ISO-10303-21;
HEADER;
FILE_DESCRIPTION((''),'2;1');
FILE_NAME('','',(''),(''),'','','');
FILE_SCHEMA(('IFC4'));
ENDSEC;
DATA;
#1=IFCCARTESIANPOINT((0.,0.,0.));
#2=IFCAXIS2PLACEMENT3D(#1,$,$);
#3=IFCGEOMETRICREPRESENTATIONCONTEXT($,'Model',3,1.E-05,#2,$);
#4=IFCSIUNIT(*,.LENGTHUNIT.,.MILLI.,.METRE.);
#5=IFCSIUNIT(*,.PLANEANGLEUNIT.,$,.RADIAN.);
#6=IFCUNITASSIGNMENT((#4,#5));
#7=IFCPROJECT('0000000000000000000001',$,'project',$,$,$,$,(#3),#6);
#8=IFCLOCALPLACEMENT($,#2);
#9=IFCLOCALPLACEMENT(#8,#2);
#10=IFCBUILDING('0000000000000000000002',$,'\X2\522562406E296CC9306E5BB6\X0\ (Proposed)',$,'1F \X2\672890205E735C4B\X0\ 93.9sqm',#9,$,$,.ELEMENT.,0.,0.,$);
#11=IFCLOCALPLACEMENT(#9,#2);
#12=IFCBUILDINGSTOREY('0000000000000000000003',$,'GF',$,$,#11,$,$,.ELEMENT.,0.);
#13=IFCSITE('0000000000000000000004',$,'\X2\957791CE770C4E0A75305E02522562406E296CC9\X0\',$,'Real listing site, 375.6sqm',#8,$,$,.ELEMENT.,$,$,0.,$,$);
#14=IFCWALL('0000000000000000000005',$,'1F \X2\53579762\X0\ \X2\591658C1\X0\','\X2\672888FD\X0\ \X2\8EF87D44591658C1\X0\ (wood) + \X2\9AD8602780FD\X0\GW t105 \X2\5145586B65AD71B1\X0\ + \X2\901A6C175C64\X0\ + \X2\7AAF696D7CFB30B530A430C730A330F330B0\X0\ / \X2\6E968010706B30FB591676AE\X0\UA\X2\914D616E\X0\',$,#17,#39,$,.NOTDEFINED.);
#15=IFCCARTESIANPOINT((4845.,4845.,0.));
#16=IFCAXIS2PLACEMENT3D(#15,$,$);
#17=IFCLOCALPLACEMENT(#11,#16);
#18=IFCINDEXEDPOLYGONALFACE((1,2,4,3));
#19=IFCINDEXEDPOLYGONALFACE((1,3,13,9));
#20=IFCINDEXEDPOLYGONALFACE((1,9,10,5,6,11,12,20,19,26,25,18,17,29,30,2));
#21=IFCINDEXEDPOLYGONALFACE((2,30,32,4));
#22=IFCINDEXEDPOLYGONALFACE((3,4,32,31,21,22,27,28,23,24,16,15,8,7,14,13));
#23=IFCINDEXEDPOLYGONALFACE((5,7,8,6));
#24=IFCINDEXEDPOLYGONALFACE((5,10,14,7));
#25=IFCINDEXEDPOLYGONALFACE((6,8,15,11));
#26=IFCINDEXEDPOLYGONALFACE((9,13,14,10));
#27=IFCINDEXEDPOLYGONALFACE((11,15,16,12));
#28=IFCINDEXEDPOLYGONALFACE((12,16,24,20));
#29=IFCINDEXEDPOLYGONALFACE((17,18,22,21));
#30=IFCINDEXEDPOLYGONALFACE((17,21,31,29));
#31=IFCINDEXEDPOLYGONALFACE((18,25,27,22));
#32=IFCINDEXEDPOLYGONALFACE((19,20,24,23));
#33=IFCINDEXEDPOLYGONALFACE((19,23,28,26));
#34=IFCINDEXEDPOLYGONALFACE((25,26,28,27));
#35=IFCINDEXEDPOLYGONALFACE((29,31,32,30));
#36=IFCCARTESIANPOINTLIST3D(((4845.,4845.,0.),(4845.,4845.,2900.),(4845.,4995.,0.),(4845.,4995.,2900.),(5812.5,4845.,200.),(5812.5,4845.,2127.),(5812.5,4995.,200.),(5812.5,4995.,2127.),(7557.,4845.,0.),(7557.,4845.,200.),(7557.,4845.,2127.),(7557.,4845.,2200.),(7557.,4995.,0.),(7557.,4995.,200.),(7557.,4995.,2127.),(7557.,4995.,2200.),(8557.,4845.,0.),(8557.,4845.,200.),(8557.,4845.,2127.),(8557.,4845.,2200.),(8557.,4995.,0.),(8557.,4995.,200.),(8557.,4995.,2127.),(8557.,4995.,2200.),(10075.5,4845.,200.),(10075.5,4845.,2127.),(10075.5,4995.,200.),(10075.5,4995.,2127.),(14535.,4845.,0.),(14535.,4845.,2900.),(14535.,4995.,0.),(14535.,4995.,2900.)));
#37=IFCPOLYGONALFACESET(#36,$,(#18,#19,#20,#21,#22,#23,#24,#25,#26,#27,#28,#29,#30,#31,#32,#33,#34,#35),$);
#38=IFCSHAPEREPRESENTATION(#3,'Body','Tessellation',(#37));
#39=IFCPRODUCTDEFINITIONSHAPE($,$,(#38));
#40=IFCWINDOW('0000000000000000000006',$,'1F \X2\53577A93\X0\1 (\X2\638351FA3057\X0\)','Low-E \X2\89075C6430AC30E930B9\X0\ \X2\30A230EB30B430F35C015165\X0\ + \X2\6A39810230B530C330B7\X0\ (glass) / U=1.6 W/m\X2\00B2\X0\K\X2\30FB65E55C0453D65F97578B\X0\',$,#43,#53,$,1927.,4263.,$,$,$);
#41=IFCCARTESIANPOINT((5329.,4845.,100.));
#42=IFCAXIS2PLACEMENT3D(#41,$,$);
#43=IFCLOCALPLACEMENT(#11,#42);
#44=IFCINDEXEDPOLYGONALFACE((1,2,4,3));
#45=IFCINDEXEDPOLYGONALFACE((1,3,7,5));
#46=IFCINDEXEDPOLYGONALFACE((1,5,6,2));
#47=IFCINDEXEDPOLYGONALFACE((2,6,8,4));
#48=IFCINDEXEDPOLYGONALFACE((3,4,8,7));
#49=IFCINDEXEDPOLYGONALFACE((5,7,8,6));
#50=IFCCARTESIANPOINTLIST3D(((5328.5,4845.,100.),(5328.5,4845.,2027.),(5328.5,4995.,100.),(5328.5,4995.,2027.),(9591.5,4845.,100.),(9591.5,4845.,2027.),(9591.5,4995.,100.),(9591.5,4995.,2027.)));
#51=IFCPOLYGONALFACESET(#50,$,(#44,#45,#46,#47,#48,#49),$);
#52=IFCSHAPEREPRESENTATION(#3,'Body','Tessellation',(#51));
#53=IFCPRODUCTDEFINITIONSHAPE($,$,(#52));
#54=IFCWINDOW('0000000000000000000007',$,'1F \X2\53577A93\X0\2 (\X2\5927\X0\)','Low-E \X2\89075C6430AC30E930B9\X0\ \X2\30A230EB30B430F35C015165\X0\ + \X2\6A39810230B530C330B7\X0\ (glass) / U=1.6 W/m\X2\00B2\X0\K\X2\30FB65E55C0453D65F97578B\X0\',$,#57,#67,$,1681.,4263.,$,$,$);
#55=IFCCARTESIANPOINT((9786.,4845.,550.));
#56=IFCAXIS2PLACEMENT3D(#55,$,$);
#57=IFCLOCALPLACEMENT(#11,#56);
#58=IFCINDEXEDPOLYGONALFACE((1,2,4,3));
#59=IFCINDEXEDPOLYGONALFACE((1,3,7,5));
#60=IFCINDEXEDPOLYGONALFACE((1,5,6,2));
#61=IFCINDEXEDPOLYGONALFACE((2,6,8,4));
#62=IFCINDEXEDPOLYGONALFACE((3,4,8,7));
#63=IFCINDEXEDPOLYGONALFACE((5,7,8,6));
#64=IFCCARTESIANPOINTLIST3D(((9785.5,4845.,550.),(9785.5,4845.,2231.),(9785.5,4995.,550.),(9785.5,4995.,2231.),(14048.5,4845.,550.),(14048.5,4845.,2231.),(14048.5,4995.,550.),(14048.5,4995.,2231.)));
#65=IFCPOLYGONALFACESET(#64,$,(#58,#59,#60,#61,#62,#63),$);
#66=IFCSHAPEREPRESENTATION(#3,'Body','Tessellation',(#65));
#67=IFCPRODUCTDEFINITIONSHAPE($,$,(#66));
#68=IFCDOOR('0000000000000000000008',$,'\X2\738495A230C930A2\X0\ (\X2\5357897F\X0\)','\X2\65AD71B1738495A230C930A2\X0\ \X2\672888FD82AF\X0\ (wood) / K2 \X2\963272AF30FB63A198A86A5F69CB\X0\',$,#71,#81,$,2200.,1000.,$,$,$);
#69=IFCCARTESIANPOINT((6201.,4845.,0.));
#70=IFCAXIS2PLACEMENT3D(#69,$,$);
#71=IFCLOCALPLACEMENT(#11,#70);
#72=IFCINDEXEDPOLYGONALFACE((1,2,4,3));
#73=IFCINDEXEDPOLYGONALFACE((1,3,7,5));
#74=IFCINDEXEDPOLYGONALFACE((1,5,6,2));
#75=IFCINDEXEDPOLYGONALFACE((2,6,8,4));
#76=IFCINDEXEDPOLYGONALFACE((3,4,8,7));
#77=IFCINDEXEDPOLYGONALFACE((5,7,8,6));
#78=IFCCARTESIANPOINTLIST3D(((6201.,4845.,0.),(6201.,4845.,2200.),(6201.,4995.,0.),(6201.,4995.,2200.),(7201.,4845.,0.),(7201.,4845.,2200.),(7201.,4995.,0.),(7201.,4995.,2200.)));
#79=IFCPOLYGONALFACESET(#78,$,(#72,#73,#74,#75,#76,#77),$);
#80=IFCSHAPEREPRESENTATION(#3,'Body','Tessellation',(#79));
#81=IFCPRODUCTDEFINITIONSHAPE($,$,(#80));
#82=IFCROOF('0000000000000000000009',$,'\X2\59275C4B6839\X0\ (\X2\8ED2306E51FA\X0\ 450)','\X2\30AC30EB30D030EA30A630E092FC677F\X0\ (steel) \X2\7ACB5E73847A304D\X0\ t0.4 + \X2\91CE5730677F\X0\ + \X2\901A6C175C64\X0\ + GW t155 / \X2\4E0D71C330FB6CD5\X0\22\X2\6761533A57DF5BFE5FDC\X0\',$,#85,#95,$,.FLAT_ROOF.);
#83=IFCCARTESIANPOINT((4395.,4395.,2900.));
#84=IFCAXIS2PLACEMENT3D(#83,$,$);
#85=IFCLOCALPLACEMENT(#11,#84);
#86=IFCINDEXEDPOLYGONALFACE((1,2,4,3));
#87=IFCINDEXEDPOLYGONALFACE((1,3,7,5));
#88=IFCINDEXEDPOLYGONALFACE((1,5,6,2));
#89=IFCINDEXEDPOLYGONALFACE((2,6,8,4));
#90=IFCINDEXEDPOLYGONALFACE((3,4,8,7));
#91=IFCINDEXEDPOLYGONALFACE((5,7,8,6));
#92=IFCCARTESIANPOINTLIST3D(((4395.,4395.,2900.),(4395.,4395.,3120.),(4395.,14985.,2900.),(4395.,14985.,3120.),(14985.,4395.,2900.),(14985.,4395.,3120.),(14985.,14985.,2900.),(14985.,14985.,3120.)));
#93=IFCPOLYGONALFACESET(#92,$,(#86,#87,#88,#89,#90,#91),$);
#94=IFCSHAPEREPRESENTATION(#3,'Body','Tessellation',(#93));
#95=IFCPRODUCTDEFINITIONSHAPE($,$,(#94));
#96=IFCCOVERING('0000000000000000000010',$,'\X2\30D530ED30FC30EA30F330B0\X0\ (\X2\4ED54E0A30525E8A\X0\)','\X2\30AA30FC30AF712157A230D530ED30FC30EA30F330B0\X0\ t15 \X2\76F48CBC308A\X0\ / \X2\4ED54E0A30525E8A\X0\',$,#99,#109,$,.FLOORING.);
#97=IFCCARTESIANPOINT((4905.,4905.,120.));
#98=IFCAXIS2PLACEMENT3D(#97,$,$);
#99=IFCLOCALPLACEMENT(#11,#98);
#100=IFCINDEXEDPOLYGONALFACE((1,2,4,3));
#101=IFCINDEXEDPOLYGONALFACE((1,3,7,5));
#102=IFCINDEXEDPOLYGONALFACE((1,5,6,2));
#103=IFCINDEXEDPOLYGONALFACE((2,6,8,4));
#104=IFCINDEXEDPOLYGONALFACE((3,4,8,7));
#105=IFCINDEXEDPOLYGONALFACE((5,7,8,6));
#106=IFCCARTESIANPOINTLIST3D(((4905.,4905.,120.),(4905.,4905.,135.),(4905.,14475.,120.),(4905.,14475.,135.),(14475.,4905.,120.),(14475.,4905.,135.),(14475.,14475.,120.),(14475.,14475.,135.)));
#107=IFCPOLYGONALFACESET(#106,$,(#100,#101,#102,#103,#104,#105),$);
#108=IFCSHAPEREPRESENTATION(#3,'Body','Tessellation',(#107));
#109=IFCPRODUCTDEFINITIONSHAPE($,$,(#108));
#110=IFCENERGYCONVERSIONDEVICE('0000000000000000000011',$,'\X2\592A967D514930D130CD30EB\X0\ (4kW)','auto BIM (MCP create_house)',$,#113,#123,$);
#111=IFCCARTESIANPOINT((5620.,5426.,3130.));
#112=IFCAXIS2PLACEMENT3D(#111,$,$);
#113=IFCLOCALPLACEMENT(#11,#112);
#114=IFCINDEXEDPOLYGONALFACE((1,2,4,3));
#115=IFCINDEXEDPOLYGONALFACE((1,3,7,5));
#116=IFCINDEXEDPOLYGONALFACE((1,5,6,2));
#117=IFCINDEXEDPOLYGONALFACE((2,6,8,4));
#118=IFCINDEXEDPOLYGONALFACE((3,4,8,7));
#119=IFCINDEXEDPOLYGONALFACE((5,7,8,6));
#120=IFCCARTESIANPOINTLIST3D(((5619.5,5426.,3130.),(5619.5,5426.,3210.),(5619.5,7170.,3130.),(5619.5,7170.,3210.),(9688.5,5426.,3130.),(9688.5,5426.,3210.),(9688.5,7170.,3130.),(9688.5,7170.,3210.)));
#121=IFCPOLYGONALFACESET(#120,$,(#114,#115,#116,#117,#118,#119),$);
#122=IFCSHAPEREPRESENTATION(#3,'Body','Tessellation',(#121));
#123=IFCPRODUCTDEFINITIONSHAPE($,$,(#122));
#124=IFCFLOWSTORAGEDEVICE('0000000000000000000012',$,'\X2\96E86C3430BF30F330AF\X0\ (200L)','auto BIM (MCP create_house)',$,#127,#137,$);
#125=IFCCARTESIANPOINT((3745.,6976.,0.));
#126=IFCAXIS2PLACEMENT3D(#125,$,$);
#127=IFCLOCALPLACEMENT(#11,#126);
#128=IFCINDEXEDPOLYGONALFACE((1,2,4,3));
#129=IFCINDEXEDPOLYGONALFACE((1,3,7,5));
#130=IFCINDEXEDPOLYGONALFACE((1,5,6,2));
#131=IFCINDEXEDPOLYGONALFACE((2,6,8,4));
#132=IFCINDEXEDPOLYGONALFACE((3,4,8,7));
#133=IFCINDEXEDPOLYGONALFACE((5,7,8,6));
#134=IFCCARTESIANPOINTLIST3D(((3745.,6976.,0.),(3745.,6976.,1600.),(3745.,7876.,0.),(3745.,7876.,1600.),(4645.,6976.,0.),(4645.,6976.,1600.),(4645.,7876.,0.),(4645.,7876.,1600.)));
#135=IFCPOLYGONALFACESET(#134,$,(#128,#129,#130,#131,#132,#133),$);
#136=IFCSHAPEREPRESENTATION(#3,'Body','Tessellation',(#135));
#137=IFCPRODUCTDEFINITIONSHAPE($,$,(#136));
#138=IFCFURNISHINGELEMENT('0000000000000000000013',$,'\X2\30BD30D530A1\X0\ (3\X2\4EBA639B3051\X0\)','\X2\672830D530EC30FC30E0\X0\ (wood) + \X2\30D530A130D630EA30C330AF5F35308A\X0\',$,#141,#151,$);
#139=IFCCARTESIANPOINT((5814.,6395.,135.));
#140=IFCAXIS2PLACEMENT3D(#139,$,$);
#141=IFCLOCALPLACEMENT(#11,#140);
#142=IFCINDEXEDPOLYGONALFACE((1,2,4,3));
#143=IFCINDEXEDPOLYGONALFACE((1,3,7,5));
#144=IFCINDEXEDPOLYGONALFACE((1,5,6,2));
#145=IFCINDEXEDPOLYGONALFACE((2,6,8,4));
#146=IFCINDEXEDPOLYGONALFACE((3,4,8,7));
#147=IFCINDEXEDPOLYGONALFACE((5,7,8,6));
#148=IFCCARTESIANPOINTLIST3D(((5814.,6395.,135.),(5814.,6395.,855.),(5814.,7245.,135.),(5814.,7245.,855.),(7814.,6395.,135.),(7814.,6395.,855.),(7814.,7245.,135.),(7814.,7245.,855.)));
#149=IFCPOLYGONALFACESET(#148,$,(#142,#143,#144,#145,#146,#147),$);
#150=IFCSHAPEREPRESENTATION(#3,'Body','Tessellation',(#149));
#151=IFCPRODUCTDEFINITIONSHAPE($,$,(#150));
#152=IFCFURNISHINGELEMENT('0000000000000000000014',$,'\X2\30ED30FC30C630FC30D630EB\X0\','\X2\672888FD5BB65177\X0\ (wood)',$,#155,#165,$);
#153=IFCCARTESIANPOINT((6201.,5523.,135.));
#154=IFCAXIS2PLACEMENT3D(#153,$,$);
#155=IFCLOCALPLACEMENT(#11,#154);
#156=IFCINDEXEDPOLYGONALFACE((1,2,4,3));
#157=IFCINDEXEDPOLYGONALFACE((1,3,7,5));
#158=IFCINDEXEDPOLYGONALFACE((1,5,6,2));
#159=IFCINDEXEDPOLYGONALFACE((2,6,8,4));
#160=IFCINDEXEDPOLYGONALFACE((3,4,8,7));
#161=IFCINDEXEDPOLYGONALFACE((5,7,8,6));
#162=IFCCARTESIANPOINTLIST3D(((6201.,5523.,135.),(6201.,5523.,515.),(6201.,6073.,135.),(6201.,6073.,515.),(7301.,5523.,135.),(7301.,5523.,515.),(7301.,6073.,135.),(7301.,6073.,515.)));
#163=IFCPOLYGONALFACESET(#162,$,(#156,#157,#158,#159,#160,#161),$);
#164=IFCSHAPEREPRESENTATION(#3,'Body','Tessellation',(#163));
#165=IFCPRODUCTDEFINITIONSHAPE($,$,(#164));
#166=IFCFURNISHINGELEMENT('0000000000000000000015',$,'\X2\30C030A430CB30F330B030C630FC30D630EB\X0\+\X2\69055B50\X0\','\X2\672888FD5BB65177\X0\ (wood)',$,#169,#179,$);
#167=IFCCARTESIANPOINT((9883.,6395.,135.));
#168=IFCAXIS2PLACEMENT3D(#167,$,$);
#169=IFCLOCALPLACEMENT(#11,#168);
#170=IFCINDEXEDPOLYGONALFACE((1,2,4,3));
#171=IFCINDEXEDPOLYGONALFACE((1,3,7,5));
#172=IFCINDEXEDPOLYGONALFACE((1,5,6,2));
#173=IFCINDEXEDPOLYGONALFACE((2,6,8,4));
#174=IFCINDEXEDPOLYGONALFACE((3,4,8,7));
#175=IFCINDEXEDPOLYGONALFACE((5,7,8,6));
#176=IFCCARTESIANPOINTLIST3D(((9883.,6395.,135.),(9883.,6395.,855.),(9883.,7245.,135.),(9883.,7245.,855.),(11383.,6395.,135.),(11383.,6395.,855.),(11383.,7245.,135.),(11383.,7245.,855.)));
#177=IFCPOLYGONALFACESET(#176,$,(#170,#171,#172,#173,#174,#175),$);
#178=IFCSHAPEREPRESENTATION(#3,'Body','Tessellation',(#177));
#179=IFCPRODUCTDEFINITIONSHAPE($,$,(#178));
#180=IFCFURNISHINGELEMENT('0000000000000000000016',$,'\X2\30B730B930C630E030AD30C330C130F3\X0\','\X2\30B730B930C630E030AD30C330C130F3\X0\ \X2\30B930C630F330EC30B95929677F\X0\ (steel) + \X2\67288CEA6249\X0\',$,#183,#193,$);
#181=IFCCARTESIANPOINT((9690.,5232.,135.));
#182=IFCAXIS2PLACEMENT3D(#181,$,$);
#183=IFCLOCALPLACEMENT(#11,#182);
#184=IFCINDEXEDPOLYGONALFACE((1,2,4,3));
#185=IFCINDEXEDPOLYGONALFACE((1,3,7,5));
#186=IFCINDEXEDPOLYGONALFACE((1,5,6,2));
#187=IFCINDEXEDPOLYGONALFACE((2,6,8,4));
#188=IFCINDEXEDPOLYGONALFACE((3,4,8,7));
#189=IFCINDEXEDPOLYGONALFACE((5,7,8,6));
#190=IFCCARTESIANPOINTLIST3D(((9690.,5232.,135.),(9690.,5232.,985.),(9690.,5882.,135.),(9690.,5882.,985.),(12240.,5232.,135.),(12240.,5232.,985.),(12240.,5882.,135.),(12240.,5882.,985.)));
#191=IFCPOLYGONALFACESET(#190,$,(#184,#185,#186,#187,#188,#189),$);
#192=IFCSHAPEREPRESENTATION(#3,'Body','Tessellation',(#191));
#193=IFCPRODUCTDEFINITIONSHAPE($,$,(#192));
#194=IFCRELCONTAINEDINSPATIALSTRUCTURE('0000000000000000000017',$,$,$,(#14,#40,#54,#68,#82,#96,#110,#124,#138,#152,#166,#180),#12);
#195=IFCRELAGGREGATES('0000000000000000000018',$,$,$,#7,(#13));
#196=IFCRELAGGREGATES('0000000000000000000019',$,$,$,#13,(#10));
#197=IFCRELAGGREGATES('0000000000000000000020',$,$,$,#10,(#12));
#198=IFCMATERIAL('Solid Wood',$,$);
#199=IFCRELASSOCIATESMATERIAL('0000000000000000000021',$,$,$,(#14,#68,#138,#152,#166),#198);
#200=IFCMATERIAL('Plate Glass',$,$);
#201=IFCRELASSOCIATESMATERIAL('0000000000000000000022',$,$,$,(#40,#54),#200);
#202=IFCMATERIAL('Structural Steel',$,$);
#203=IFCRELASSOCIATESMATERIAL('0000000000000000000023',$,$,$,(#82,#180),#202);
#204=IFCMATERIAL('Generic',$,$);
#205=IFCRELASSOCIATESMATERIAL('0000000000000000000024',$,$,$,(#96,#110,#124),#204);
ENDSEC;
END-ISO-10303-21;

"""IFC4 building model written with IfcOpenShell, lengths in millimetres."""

from ifc_helpers import new_model, si_unit, frame, frame_2d, origin, place, context, project, spatial, rectangle, extrude, material, element, fill, save


model = new_model("IFC4")

# Units and contexts
model_context = context("Model", 3, precision=1e-05, world=origin())
ifc_project = project(units=[si_unit("LENGTHUNIT", "METRE", prefix="MILLI"), si_unit("PLANEANGLEUNIT", "RADIAN")], contexts=[model_context])

# Site, building, storey
site_placement = place(None, origin())
site = spatial("IfcSite", under=ifc_project, at=site_placement, Name="長野県上田市別所温泉", ObjectType="Real listing site, 375.6sqm", CompositionType="ELEMENT", RefElevation=0.0)
building_placement = place(site_placement, origin())
building = spatial("IfcBuilding", under=site, at=building_placement, Name="別所温泉の家 (Proposed)", ObjectType="1F 木造平屋 93.9sqm", CompositionType="ELEMENT", ElevationOfRefHeight=0.0, ElevationOfTerrain=0.0)
storey_placement = place(building_placement, origin())
storey = spatial("IfcBuildingStorey", under=building, at=storey_placement, Name="GF", CompositionType="ELEMENT", Elevation=0.0)

# Shared definitions
ifc_material_1 = material(Name="Solid Wood")

# Wall, openings, windows, door
wall_1_placement = place(storey_placement, frame((4845.0, 4845.0, 0.0)))
wall_1 = element("IfcWall", 1, at=wall_1_placement, inside=storey, material=ifc_material_1, Name="1F 南面 外壁", Description="木製 軸組外壁 (wood) + 高性能GW t105 充填断熱 + 通気層 + 窯業系サイディング / 準耐火・外皮UA配慮", PredefinedType="NOTDEFINED", context=model_context, shape_type="SweptSolid", body=[
    extrude(rectangle(XDim=9690.0, YDim=150.0, at=frame_2d((4845.0, 75.0))), frame((4845.0, 4845.0, 0.0)), (0.0, 0.0, 1.0), 2900.0),
])
opening_1_placement = place(storey_placement, frame((5329.0, 4845.0, 100.0)))
opening_1 = element("IfcOpeningElement", 2, at=opening_1_placement, cuts=wall_1, PredefinedType="NOTDEFINED", context=model_context, shape_type="SweptSolid", body=[
    extrude(rectangle(XDim=4263.0, YDim=150.0, at=frame_2d((2131.0, 75.0))), frame((5329.0, 4845.0, 100.0)), (0.0, 0.0, 1.0), 1927.0),
])
opening_2_placement = place(storey_placement, frame((9786.0, 4845.0, 550.0)))
opening_2 = element("IfcOpeningElement", 3, at=opening_2_placement, cuts=wall_1, PredefinedType="NOTDEFINED", context=model_context, shape_type="SweptSolid", body=[
    extrude(rectangle(XDim=4263.0, YDim=150.0, at=frame_2d((2131.0, 75.0))), frame((9786.0, 4845.0, 550.0)), (0.0, 0.0, 1.0), 1681.0),
])
opening_3_placement = place(storey_placement, frame((6201.0, 4845.0, 0.0)))
opening_3 = element("IfcOpeningElement", 4, at=opening_3_placement, cuts=wall_1, PredefinedType="NOTDEFINED", context=model_context, shape_type="SweptSolid", body=[
    extrude(rectangle(XDim=1000.0, YDim=150.0, at=frame_2d((500.0, 75.0))), frame((6201.0, 4845.0, 0.0)), (0.0, 0.0, 1.0), 2200.0),
])
ifc_material_2 = material(Name="Plate Glass")
window_1_placement = place(storey_placement, frame((5329.0, 4845.0, 100.0)))
window_1 = element("IfcWindow", 5, at=window_1_placement, inside=storey, material=ifc_material_2, Name="1F 南窓1 (掃出し)", Description="Low-E 複層ガラス アルゴン封入 + 樹脂サッシ (glass) / U=1.6 W/m²K・日射取得型", OverallHeight=1927.0, OverallWidth=4263.0, context=model_context, shape_type="SweptSolid", body=[
    extrude(rectangle(XDim=4263.0, YDim=150.0, at=frame_2d((2131.0, 75.0))), frame((5329.0, 4845.0, 100.0)), (0.0, 0.0, 1.0), 1927.0),
])
fill(opening_1, window_1)
window_2_placement = place(storey_placement, frame((9786.0, 4845.0, 550.0)))
window_2 = element("IfcWindow", 6, at=window_2_placement, inside=storey, material=ifc_material_2, Name="1F 南窓2 (大)", Description="Low-E 複層ガラス アルゴン封入 + 樹脂サッシ (glass) / U=1.6 W/m²K・日射取得型", OverallHeight=1681.0, OverallWidth=4263.0, context=model_context, shape_type="SweptSolid", body=[
    extrude(rectangle(XDim=4263.0, YDim=150.0, at=frame_2d((2131.0, 75.0))), frame((9786.0, 4845.0, 550.0)), (0.0, 0.0, 1.0), 1681.0),
])
fill(opening_2, window_2)
door_placement = place(storey_placement, frame((6201.0, 4845.0, 0.0)))
door = element("IfcDoor", 7, at=door_placement, inside=storey, material=ifc_material_1, Name="玄関ドア (南西)", Description="断熱玄関ドア 木製芯 (wood) / K2 防犯・採風機構", OverallHeight=2200.0, OverallWidth=1000.0, context=model_context, shape_type="SweptSolid", body=[
    extrude(rectangle(XDim=1000.0, YDim=150.0, at=frame_2d((500.0, 75.0))), frame((6201.0, 4845.0, 0.0)), (0.0, 0.0, 1.0), 2200.0),
])
fill(opening_3, door)

# Roof
ifc_material_3 = material(Name="Structural Steel")
roof_placement = place(storey_placement, frame((4395.0, 4395.0, 2900.0)))
element("IfcRoof", 8, at=roof_placement, inside=storey, material=ifc_material_3, Name="大屋根 (軒の出 450)", Description="ガルバリウム鋼板 (steel) 立平葺き t0.4 + 野地板 + 通気層 + GW t155 / 不燃・法22条区域対応", PredefinedType="FLAT_ROOF", context=model_context, shape_type="SweptSolid", body=[
    extrude(rectangle(XDim=10590.0, YDim=10590.0, at=frame_2d((5295.0, 5295.0))), frame((4395.0, 4395.0, 2900.0)), (0.0, 0.0, 1.0), 220.0),
])

# Covering
ifc_material_4 = material(Name="Generic")
covering_placement = place(storey_placement, frame((4905.0, 4905.0, 120.0)))
element("IfcCovering", 9, at=covering_placement, inside=storey, material=ifc_material_4, Name="フローリング (仕上げ床)", Description="オーク無垢フローリング t15 直貼り / 仕上げ床", PredefinedType="FLOORING", context=model_context, shape_type="SweptSolid", body=[
    extrude(rectangle(XDim=9570.0, YDim=9570.0, at=frame_2d((4785.0, 4785.0))), frame((4905.0, 4905.0, 120.0)), (0.0, 0.0, 1.0), 15.0),
])

# Energy conversion device
energy_conversion_device_placement = place(storey_placement, frame((5620.0, 5426.0, 3130.0)))
element("IfcEnergyConversionDevice", 10, at=energy_conversion_device_placement, inside=storey, material=ifc_material_4, Name="太陽光パネル (4kW)", Description="auto BIM (MCP create_house)", context=model_context, shape_type="SweptSolid", body=[
    extrude(rectangle(XDim=4069.0, YDim=1744.0, at=frame_2d((2034.0, 872.0))), frame((5620.0, 5426.0, 3130.0)), (0.0, 0.0, 1.0), 80.0),
])

# Flow storage device
flow_storage_device_placement = place(storey_placement, frame((3745.0, 6976.0, 0.0)))
element("IfcFlowStorageDevice", 11, at=flow_storage_device_placement, inside=storey, material=ifc_material_4, Name="雨水タンク (200L)", Description="auto BIM (MCP create_house)", context=model_context, shape_type="SweptSolid", body=[
    extrude(rectangle(XDim=900.0, YDim=900.0, at=frame_2d((450.0, 450.0))), frame((3745.0, 6976.0, 0.0)), (0.0, 0.0, 1.0), 1600.0),
])

# Furnishing elements
furnishing_1_placement = place(storey_placement, frame((5814.0, 6395.0, 135.0)))
element("IfcFurnishingElement", 12, at=furnishing_1_placement, inside=storey, material=ifc_material_1, Name="ソファ (3人掛け)", Description="木フレーム (wood) + ファブリック張り", context=model_context, shape_type="SweptSolid", body=[
    extrude(rectangle(XDim=2000.0, YDim=850.0, at=frame_2d((1000.0, 425.0))), frame((5814.0, 6395.0, 135.0)), (0.0, 0.0, 1.0), 720.0),
])
furnishing_2_placement = place(storey_placement, frame((6201.0, 5523.0, 135.0)))
element("IfcFurnishingElement", 13, at=furnishing_2_placement, inside=storey, material=ifc_material_1, Name="ローテーブル", Description="木製家具 (wood)", context=model_context, shape_type="SweptSolid", body=[
    extrude(rectangle(XDim=1100.0, YDim=550.0, at=frame_2d((550.0, 275.0))), frame((6201.0, 5523.0, 135.0)), (0.0, 0.0, 1.0), 380.0),
])
furnishing_3_placement = place(storey_placement, frame((9883.0, 6395.0, 135.0)))
element("IfcFurnishingElement", 14, at=furnishing_3_placement, inside=storey, material=ifc_material_1, Name="ダイニングテーブル+椅子", Description="木製家具 (wood)", context=model_context, shape_type="SweptSolid", body=[
    extrude(rectangle(XDim=1500.0, YDim=850.0, at=frame_2d((750.0, 425.0))), frame((9883.0, 6395.0, 135.0)), (0.0, 0.0, 1.0), 720.0),
])
furnishing_4_placement = place(storey_placement, frame((9690.0, 5232.0, 135.0)))
element("IfcFurnishingElement", 15, at=furnishing_4_placement, inside=storey, material=ifc_material_3, Name="システムキッチン", Description="システムキッチン ステンレス天板 (steel) + 木質扉", context=model_context, shape_type="SweptSolid", body=[
    extrude(rectangle(XDim=2550.0, YDim=650.0, at=frame_2d((1275.0, 325.0))), frame((9690.0, 5232.0, 135.0)), (0.0, 0.0, 1.0), 850.0),
])

save(model, "model.ifc")
